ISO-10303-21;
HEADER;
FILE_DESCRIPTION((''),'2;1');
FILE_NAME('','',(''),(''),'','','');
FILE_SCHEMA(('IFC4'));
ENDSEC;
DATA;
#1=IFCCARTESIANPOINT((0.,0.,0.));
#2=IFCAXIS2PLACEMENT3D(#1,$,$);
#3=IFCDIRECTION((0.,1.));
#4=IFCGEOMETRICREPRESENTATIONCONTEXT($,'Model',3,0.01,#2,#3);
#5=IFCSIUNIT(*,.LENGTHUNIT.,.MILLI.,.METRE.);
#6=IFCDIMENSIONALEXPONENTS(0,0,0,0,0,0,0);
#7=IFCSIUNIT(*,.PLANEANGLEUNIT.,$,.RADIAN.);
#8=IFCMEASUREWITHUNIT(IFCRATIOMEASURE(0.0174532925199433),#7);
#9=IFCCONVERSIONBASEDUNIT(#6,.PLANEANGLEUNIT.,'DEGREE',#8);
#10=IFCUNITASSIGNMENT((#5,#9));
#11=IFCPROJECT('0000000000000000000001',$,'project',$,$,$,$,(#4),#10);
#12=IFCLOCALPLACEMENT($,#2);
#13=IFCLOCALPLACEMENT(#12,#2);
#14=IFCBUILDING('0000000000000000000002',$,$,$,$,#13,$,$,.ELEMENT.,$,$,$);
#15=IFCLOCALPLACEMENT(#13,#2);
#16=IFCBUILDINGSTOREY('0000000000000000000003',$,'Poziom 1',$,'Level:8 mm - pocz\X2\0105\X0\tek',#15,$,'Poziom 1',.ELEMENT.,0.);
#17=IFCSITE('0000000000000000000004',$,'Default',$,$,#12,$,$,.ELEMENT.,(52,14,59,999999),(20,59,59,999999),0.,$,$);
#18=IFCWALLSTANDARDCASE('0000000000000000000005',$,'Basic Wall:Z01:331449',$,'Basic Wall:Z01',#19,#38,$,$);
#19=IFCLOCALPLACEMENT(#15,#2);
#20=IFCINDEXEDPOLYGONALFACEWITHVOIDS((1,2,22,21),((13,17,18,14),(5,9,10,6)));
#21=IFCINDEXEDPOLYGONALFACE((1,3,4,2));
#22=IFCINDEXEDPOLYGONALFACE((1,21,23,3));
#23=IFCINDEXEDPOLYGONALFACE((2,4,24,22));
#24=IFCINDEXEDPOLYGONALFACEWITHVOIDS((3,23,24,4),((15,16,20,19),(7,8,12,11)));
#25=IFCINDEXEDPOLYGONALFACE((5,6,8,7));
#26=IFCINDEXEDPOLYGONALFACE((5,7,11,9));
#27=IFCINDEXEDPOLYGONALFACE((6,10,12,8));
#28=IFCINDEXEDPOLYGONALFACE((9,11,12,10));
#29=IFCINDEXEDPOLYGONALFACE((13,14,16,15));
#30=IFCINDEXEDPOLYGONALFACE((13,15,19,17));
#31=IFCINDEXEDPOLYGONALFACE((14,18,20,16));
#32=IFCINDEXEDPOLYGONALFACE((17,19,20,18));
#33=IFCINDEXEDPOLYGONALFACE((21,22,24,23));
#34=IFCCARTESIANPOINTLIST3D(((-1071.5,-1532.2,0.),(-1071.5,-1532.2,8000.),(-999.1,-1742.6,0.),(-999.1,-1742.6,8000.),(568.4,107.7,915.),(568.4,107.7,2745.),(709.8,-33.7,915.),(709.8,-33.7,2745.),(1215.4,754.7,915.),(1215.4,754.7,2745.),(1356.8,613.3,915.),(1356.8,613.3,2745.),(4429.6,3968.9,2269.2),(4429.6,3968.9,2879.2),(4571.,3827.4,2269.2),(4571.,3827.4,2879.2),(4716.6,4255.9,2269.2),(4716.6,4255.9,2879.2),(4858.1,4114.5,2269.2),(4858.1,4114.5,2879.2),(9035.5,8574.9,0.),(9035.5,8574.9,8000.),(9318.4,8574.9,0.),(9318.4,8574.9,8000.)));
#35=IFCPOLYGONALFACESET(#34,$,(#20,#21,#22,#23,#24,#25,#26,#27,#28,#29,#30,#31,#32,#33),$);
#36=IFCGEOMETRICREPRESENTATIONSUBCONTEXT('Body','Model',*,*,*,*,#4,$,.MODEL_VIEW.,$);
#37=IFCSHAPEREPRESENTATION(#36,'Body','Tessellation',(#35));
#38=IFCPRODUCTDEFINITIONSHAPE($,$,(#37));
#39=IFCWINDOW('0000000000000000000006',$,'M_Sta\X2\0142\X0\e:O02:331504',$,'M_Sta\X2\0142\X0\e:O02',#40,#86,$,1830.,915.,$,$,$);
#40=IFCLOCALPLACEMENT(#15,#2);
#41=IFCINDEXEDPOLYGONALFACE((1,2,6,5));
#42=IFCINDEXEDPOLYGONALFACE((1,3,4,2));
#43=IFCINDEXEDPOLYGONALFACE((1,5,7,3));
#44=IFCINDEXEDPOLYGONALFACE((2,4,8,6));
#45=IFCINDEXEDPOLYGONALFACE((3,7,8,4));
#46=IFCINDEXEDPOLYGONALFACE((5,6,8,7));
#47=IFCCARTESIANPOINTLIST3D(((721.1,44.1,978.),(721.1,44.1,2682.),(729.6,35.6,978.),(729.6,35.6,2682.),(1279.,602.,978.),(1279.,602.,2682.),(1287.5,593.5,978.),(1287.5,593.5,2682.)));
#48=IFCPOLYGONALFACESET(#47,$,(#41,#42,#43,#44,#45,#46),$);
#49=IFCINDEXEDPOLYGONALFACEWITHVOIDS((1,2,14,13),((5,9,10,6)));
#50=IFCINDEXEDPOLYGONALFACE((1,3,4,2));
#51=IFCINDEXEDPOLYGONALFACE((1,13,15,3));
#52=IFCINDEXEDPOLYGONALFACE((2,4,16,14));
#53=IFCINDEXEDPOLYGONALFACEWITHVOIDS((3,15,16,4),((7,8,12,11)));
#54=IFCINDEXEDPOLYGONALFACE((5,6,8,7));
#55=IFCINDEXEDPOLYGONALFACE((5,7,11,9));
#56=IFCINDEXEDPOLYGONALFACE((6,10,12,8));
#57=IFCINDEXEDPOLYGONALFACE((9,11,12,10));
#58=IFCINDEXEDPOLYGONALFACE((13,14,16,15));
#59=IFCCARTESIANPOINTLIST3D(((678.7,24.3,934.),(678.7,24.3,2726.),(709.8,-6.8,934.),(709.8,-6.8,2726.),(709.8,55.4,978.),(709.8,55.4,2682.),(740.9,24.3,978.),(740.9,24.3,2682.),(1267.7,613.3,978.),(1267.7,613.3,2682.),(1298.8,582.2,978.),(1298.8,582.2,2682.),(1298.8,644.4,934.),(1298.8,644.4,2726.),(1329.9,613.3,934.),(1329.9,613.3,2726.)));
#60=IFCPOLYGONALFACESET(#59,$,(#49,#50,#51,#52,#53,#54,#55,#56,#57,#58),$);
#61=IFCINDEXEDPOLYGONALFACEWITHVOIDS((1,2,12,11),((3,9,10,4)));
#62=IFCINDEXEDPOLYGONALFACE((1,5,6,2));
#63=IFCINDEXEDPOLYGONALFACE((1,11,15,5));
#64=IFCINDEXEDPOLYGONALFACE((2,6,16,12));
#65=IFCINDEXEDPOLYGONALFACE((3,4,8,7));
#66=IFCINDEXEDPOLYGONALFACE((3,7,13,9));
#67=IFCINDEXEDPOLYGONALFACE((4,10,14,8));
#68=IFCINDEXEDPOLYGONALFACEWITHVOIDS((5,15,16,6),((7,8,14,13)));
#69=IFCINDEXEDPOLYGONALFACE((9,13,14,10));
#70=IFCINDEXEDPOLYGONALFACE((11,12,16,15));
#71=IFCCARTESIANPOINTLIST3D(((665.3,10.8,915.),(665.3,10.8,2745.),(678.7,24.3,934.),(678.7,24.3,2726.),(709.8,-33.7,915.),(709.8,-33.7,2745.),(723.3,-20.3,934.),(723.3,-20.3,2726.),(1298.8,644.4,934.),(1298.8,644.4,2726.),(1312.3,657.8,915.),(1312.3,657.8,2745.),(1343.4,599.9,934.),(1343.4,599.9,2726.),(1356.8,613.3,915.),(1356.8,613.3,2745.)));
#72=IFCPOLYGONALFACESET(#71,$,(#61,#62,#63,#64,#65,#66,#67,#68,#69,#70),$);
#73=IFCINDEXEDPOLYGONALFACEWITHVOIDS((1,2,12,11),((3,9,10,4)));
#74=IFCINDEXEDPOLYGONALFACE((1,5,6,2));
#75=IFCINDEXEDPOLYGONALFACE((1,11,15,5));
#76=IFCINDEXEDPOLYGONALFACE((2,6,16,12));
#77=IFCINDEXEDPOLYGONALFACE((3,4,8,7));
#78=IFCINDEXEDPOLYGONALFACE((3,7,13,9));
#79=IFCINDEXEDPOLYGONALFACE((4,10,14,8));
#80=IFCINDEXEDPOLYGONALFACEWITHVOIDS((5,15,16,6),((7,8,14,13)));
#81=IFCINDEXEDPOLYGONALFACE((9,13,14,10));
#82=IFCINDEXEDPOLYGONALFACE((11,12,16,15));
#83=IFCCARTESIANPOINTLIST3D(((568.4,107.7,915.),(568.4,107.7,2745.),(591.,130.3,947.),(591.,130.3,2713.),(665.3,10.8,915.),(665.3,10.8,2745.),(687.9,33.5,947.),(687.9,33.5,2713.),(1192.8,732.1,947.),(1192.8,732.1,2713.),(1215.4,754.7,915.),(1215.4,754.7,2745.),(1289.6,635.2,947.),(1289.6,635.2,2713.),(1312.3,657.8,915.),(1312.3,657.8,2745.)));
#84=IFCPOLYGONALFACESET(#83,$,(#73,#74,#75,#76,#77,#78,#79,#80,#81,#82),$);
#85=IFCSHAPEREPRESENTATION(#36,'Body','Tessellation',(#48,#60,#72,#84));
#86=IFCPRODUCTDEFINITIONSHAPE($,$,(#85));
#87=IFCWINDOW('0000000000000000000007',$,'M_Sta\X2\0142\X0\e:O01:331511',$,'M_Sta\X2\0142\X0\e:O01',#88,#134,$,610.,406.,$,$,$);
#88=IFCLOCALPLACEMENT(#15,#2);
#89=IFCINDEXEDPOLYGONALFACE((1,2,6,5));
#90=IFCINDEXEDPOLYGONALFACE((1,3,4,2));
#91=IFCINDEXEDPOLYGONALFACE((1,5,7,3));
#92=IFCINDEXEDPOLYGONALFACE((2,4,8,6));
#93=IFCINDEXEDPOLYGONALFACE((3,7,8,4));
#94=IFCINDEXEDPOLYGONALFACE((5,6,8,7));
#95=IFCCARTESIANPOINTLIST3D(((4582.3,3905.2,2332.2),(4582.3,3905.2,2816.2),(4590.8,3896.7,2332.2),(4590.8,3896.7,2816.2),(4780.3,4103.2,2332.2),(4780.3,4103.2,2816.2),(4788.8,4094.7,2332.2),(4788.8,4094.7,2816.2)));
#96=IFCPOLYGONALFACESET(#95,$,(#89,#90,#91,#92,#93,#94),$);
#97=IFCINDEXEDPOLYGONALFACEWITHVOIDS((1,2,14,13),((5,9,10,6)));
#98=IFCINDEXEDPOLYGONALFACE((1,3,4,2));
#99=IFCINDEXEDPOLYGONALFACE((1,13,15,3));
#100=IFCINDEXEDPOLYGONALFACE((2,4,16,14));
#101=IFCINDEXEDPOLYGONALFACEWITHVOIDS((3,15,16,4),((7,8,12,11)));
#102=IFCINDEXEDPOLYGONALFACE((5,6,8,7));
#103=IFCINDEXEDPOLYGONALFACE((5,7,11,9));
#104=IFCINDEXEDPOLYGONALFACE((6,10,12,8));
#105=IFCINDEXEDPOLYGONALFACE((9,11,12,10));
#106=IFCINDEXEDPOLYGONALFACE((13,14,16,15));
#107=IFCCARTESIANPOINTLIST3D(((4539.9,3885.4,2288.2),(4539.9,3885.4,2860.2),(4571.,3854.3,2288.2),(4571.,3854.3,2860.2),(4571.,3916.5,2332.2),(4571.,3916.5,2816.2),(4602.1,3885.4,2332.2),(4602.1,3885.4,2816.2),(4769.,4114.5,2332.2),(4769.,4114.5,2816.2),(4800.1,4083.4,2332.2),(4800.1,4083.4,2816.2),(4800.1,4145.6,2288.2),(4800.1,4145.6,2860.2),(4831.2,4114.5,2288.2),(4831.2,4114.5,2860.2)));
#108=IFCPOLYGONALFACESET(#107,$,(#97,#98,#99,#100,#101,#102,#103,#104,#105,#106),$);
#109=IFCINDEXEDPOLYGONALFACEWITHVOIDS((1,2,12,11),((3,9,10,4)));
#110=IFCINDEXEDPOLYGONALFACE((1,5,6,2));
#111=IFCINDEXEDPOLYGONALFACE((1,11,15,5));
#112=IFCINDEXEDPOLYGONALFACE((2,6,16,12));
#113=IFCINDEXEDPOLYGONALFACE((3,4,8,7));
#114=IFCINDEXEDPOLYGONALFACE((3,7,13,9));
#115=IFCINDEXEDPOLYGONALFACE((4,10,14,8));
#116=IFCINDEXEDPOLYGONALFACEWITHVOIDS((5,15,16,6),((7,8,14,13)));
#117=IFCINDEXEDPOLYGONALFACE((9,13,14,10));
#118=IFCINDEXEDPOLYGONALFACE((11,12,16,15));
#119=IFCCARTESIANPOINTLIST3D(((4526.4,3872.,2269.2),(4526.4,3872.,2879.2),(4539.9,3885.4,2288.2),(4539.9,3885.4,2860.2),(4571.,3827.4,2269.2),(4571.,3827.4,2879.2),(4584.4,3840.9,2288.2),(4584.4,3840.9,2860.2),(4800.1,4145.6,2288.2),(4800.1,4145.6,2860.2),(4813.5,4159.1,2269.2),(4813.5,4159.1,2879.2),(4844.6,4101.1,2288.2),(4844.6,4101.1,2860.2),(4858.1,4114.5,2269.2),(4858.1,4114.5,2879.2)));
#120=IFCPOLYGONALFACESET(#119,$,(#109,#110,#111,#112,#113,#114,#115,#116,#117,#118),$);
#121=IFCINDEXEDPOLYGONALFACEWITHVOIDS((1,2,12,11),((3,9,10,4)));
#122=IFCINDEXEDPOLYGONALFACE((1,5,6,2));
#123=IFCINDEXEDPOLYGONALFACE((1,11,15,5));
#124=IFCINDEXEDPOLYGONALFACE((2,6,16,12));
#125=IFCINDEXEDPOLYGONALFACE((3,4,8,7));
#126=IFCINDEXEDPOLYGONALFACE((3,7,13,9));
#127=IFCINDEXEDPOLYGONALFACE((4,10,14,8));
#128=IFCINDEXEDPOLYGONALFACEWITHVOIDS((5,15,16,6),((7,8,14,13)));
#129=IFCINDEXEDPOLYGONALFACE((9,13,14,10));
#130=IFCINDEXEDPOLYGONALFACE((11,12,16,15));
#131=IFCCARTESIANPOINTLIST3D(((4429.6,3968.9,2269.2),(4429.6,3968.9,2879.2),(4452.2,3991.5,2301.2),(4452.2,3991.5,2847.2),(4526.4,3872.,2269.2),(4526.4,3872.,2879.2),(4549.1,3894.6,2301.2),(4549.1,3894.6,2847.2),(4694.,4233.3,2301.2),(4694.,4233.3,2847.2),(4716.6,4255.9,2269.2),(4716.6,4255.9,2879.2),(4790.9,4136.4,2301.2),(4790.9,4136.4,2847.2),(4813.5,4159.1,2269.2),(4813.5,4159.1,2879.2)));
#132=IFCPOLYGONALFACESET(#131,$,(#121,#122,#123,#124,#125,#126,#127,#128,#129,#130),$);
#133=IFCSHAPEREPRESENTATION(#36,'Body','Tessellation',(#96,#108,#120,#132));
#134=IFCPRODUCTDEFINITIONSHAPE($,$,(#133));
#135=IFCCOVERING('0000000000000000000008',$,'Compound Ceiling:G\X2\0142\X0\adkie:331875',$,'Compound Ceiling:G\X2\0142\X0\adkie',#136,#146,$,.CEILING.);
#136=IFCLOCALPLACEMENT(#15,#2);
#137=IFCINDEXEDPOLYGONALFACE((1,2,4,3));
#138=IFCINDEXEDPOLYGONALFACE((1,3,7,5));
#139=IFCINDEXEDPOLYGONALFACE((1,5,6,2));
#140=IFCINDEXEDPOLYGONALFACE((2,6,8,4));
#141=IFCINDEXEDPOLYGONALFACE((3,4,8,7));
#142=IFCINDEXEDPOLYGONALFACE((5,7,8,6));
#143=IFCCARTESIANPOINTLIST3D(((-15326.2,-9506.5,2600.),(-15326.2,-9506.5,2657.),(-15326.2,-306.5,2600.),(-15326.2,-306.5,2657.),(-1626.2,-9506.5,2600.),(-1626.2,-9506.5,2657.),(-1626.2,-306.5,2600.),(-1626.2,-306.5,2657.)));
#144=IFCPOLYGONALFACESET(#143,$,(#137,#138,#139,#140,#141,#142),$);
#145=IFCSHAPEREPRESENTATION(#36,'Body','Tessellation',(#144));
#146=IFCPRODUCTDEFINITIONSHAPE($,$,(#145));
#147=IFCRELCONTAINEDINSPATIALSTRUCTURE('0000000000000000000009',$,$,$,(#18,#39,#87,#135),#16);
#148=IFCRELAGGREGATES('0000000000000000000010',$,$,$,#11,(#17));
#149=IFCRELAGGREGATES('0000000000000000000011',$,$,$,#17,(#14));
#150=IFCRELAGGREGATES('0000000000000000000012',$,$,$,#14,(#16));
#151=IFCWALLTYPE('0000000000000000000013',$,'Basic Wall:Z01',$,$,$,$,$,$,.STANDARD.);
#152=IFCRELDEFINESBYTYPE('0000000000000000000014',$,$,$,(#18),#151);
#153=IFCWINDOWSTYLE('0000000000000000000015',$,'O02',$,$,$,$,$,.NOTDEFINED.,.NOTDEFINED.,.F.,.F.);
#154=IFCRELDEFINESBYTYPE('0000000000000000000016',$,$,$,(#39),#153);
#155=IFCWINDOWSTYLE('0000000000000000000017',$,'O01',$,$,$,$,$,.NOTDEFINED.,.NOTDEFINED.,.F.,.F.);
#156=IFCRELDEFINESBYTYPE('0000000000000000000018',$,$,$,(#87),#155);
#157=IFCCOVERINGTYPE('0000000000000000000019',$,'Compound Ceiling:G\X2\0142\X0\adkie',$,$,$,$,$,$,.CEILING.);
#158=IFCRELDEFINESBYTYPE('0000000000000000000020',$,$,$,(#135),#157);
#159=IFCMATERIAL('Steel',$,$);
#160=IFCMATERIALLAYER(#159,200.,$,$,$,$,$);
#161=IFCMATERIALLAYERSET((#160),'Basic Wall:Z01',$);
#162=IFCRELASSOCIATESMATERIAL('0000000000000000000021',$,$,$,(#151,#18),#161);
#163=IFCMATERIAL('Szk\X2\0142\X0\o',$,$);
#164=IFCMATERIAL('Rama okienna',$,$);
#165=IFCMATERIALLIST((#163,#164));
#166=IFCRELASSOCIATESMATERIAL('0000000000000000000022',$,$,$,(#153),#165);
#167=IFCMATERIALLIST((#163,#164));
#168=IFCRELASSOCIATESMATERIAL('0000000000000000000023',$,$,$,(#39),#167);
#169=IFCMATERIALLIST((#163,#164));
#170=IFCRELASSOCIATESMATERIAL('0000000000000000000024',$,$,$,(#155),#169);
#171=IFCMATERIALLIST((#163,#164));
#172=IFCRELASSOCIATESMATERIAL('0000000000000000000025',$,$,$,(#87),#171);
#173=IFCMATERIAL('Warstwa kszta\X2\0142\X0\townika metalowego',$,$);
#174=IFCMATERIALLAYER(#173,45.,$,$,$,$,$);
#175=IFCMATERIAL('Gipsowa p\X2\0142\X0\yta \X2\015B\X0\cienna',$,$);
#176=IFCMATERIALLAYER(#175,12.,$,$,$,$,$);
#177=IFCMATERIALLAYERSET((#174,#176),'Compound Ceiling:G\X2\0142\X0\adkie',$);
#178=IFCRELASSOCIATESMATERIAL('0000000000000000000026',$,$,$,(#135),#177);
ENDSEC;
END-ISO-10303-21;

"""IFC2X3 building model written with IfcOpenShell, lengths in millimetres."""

from ifc_helpers import new_model, entity, si_unit, converted_unit, direction, frame, frame_2d, origin, origin_2d_with_axis, place, context, subcontext, project, spatial, polyline, rectangle, outline, extrude, source, transform, mapped, material, material_list, layer, layer_set, layer_usage, type_object, type_shapes, element, fill, save


model = new_model("IFC2X3")

# Units and contexts
model_context = context("Model", 3, precision=0.01, world=origin(), true_north=direction((0.0, 1.0)))
body_context = subcontext(model_context, "Body", "Model", "MODEL_VIEW")
ifc_project = project(units=[si_unit("LENGTHUNIT", "METRE", prefix="MILLI"), converted_unit("PLANEANGLEUNIT", "DEGREE", entity("IfcRatioMeasure", 0.0174532925199433), si_unit("PLANEANGLEUNIT", "RADIAN"), dimensions=[0, 0, 0, 0, 0, 0, 0])], contexts=[model_context])

# Site, building, storey
site_placement = place(None, origin())
site = spatial("IfcSite", under=ifc_project, at=site_placement, Name="Default", CompositionType="ELEMENT", RefLatitude=(52, 14, 59, 999999), RefLongitude=(20, 59, 59, 999999), RefElevation=0.0)
building_placement = place(site_placement, origin())
building = spatial("IfcBuilding", under=site, at=building_placement, CompositionType="ELEMENT")
storey_placement = place(building_placement, origin())
storey = spatial("IfcBuildingStorey", under=building, at=storey_placement, Name="Poziom 1", ObjectType="Level:8 mm - początek", LongName="Poziom 1", CompositionType="ELEMENT", Elevation=0.0)

# Shared definitions
ifc_material_1 = material(Name="Steel")
ifc_layer_1 = layer(ifc_material_1, 200.0)
ifc_layer_set_1 = layer_set([ifc_layer_1], Name="Basic Wall:Z01")
wall_type = type_object("IfcWallType", Name="Basic Wall:Z01", PredefinedType="STANDARD", material=ifc_layer_set_1)

# Wall, openings, windows
ifc_layer_usage_1 = layer_usage(ifc_layer_set_1, "AXIS2", "NEGATIVE", 100.0)
wall_1_placement = place(storey_placement, frame((-1069.8, -1671.9, 0.0), z_axis=(0.0, 0.0, 1.0), x_axis=(0.707107, 0.707107, 0.0)))
wall_1 = element("IfcWallStandardCase", 1, at=wall_1_placement, inside=storey, type_object=wall_type, material=ifc_layer_usage_1, Name="Basic Wall:Z01:331449", ObjectType="Basic Wall:Z01", context=body_context, shape_type="SweptSolid", body=[
    extrude(outline(polyline([(14591.1, -100.0), (14391.1, 100.0), (13684.0, 100.0), (97.5, 100.0), (0.0, -100.0), (14591.1, -100.0)])), origin(), (0.0, 0.0, 1.0), 8000.0),
])
opening_1_placement = place(wall_1_placement, frame((3331.7, 100.0, 915.0)))
opening_1 = element("IfcOpeningElement", 2, at=opening_1_placement, cuts=wall_1, ObjectType="Opening", context=body_context, shape_type="SweptSolid", body=[
    extrude(rectangle(XDim=1830.0, YDim=915.0, at=frame_2d((915.0, 457.5), x_axis=(1.0, 0.0))), frame((0.0, 0.0, 0.0), z_axis=(0.0, -1.0, 0.0), x_axis=(0.0, 0.0, 1.0)), (0.0, 0.0, 1.0), 200.0),
])
opening_2_placement = place(wall_1_placement, frame((8283.2, 100.0, 2269.2)))
opening_2 = element("IfcOpeningElement", 3, at=opening_2_placement, cuts=wall_1, ObjectType="Opening", context=body_context, shape_type="SweptSolid", body=[
    extrude(rectangle(XDim=610.0, YDim=406.0, at=frame_2d((305.0, 203.0), x_axis=(1.0, 0.0))), frame((0.0, 0.0, 0.0), z_axis=(0.0, -1.0, 0.0), x_axis=(0.0, 0.0, 1.0)), (0.0, 0.0, 1.0), 200.0),
])
ifc_material_2 = material(Name="Szkło")
ifc_material_3 = material(Name="Rama okienna")
ifc_material_list_1 = material_list([ifc_material_2, ifc_material_3])
ifc_material_list_2 = material_list([ifc_material_2, ifc_material_3])
window_style_1 = type_object("IfcWindowStyle", Name="O02", ConstructionType="NOTDEFINED", OperationType="NOTDEFINED", ParameterTakesPrecedence=False, Sizeable=False, material=ifc_material_list_2)
shared_shape_1 = source(origin(), body_context, "Body", "SweptSolid", [
    extrude(rectangle(XDim=12.0, YDim=789.0, at=frame_2d((0.0, 0.0), x_axis=(1.0, 0.0))), frame((457.5, 159.0, 63.0), z_axis=(0.0, 0.0, 1.0), x_axis=(0.0, -1.0, 0.0)), (0.0, 0.0, 1.0), 1704.0),
    extrude(outline(polyline([(-438.5, -896.0), (438.5, -896.0), (438.5, 896.0), (-438.5, 896.0), (-438.5, -896.0)]), holes=[polyline([(-394.5, -852.0), (-394.5, 852.0), (394.5, 852.0), (394.5, -852.0), (-394.5, -852.0)])]), frame((457.5, 137.0, 915.0), z_axis=(0.0, 1.0, 0.0), x_axis=(1.0, 0.0, 0.0)), (0.0, 0.0, 1.0), 44.0),
    extrude(outline(polyline([(-457.5, -915.0), (457.5, -915.0), (457.5, 915.0), (-457.5, 915.0), (-457.5, -915.0)]), holes=[polyline([(-438.5, -896.0), (-438.5, 896.0), (438.5, 896.0), (438.5, -896.0), (-438.5, -896.0)])]), frame((457.5, 137.0, 915.0), z_axis=(0.0, 1.0, 0.0), x_axis=(1.0, 0.0, 0.0)), (0.0, 0.0, 1.0), 63.0),
    extrude(outline(polyline([(-457.5, -915.0), (457.5, -915.0), (457.5, 915.0), (-457.5, 915.0), (-457.5, -915.0)]), holes=[polyline([(-425.5, -883.0), (-425.5, 883.0), (425.5, 883.0), (425.5, -883.0), (-425.5, -883.0)])]), frame((457.5, 0.0, 915.0), z_axis=(0.0, 1.0, 0.0), x_axis=(1.0, 0.0, 0.0)), (0.0, 0.0, 1.0), 137.0),
])
type_shapes(window_style_1, [shared_shape_1])
window_1_placement = place(opening_1_placement, frame((0.0, 0.0, 0.0), z_axis=(0.0, 0.0, 1.0), x_axis=(-1.0, 0.0, 0.0)))
window_1 = element("IfcWindow", 4, at=window_1_placement, inside=storey, type_object=window_style_1, material=ifc_material_list_1, Name="M_Stałe:O02:331504", ObjectType="M_Stałe:O02", OverallHeight=1830.0, OverallWidth=915.0, context=body_context, shape_type="MappedRepresentation", body=[
    mapped(shared_shape_1, transform((0.0, 0.0, 0.0), scale=1.0)),
])
fill(opening_1, window_1)
ifc_material_list_3 = material_list([ifc_material_2, ifc_material_3])
ifc_material_list_4 = material_list([ifc_material_2, ifc_material_3])
window_style_2 = type_object("IfcWindowStyle", Name="O01", ConstructionType="NOTDEFINED", OperationType="NOTDEFINED", ParameterTakesPrecedence=False, Sizeable=False, material=ifc_material_list_4)
shared_shape_2 = source(origin(), body_context, "Body", "SweptSolid", [
    extrude(rectangle(XDim=12.0, YDim=280.0, at=frame_2d((0.0, 0.0), x_axis=(1.0, 0.0))), frame((203.0, 159.0, 63.0), z_axis=(0.0, 0.0, 1.0), x_axis=(0.0, -1.0, 0.0)), (0.0, 0.0, 1.0), 484.0),
    extrude(outline(polyline([(-184.0, -286.0), (184.0, -286.0), (184.0, 286.0), (-184.0, 286.0), (-184.0, -286.0)]), holes=[polyline([(-140.0, -242.0), (-140.0, 242.0), (140.0, 242.0), (140.0, -242.0), (-140.0, -242.0)])]), frame((203.0, 137.0, 305.0), z_axis=(0.0, 1.0, 0.0), x_axis=(1.0, 0.0, 0.0)), (0.0, 0.0, 1.0), 44.0),
    extrude(outline(polyline([(-203.0, -305.0), (203.0, -305.0), (203.0, 305.0), (-203.0, 305.0), (-203.0, -305.0)]), holes=[polyline([(-184.0, -286.0), (-184.0, 286.0), (184.0, 286.0), (184.0, -286.0), (-184.0, -286.0)])]), frame((203.0, 137.0, 305.0), z_axis=(0.0, 1.0, 0.0), x_axis=(1.0, 0.0, 0.0)), (0.0, 0.0, 1.0), 63.0),
    extrude(outline(polyline([(-203.0, -305.0), (203.0, -305.0), (203.0, 305.0), (-203.0, 305.0), (-203.0, -305.0)]), holes=[polyline([(-171.0, -273.0), (-171.0, 273.0), (171.0, 273.0), (171.0, -273.0), (-171.0, -273.0)])]), frame((203.0, 0.0, 305.0), z_axis=(0.0, 1.0, 0.0), x_axis=(1.0, 0.0, 0.0)), (0.0, 0.0, 1.0), 137.0),
])
type_shapes(window_style_2, [shared_shape_2])
window_2_placement = place(opening_2_placement, frame((0.0, 0.0, 0.0), z_axis=(0.0, 0.0, 1.0), x_axis=(-1.0, 0.0, 0.0)))
window_2 = element("IfcWindow", 5, at=window_2_placement, inside=storey, type_object=window_style_2, material=ifc_material_list_3, Name="M_Stałe:O01:331511", ObjectType="M_Stałe:O01", OverallHeight=610.0, OverallWidth=406.0, context=body_context, shape_type="MappedRepresentation", body=[
    mapped(shared_shape_2, transform((0.0, 0.0, 0.0), scale=1.0)),
])
fill(opening_2, window_2)

# Covering
ifc_material_4 = material(Name="Warstwa kształtownika metalowego")
ifc_layer_2 = layer(ifc_material_4, 45.0)
ifc_material_5 = material(Name="Gipsowa płyta ścienna")
ifc_layer_3 = layer(ifc_material_5, 12.0)
ifc_layer_set_2 = layer_set([ifc_layer_2, ifc_layer_3], Name="Compound Ceiling:Gładkie")
ifc_layer_usage_2 = layer_usage(ifc_layer_set_2, "AXIS3", "POSITIVE", 0.0)
covering_type = type_object("IfcCoveringType", Name="Compound Ceiling:Gładkie", PredefinedType="CEILING")
covering_placement = place(storey_placement, origin())
element("IfcCovering", 6, at=covering_placement, inside=storey, type_object=covering_type, material=ifc_layer_usage_2, Name="Compound Ceiling:Gładkie:331875", ObjectType="Compound Ceiling:Gładkie", PredefinedType="CEILING", context=body_context, shape_type="SweptSolid", body=[
    extrude(rectangle(XDim=13700.0, YDim=9200.0, at=origin_2d_with_axis()), frame((-8476.2, -4906.5, 2600.0), z_axis=(0.0, 0.0, 1.0), x_axis=(-1.0, 0.0, 0.0)), (0.0, 0.0, 1.0), 57.0),
])

save(model, "model.ifc")
